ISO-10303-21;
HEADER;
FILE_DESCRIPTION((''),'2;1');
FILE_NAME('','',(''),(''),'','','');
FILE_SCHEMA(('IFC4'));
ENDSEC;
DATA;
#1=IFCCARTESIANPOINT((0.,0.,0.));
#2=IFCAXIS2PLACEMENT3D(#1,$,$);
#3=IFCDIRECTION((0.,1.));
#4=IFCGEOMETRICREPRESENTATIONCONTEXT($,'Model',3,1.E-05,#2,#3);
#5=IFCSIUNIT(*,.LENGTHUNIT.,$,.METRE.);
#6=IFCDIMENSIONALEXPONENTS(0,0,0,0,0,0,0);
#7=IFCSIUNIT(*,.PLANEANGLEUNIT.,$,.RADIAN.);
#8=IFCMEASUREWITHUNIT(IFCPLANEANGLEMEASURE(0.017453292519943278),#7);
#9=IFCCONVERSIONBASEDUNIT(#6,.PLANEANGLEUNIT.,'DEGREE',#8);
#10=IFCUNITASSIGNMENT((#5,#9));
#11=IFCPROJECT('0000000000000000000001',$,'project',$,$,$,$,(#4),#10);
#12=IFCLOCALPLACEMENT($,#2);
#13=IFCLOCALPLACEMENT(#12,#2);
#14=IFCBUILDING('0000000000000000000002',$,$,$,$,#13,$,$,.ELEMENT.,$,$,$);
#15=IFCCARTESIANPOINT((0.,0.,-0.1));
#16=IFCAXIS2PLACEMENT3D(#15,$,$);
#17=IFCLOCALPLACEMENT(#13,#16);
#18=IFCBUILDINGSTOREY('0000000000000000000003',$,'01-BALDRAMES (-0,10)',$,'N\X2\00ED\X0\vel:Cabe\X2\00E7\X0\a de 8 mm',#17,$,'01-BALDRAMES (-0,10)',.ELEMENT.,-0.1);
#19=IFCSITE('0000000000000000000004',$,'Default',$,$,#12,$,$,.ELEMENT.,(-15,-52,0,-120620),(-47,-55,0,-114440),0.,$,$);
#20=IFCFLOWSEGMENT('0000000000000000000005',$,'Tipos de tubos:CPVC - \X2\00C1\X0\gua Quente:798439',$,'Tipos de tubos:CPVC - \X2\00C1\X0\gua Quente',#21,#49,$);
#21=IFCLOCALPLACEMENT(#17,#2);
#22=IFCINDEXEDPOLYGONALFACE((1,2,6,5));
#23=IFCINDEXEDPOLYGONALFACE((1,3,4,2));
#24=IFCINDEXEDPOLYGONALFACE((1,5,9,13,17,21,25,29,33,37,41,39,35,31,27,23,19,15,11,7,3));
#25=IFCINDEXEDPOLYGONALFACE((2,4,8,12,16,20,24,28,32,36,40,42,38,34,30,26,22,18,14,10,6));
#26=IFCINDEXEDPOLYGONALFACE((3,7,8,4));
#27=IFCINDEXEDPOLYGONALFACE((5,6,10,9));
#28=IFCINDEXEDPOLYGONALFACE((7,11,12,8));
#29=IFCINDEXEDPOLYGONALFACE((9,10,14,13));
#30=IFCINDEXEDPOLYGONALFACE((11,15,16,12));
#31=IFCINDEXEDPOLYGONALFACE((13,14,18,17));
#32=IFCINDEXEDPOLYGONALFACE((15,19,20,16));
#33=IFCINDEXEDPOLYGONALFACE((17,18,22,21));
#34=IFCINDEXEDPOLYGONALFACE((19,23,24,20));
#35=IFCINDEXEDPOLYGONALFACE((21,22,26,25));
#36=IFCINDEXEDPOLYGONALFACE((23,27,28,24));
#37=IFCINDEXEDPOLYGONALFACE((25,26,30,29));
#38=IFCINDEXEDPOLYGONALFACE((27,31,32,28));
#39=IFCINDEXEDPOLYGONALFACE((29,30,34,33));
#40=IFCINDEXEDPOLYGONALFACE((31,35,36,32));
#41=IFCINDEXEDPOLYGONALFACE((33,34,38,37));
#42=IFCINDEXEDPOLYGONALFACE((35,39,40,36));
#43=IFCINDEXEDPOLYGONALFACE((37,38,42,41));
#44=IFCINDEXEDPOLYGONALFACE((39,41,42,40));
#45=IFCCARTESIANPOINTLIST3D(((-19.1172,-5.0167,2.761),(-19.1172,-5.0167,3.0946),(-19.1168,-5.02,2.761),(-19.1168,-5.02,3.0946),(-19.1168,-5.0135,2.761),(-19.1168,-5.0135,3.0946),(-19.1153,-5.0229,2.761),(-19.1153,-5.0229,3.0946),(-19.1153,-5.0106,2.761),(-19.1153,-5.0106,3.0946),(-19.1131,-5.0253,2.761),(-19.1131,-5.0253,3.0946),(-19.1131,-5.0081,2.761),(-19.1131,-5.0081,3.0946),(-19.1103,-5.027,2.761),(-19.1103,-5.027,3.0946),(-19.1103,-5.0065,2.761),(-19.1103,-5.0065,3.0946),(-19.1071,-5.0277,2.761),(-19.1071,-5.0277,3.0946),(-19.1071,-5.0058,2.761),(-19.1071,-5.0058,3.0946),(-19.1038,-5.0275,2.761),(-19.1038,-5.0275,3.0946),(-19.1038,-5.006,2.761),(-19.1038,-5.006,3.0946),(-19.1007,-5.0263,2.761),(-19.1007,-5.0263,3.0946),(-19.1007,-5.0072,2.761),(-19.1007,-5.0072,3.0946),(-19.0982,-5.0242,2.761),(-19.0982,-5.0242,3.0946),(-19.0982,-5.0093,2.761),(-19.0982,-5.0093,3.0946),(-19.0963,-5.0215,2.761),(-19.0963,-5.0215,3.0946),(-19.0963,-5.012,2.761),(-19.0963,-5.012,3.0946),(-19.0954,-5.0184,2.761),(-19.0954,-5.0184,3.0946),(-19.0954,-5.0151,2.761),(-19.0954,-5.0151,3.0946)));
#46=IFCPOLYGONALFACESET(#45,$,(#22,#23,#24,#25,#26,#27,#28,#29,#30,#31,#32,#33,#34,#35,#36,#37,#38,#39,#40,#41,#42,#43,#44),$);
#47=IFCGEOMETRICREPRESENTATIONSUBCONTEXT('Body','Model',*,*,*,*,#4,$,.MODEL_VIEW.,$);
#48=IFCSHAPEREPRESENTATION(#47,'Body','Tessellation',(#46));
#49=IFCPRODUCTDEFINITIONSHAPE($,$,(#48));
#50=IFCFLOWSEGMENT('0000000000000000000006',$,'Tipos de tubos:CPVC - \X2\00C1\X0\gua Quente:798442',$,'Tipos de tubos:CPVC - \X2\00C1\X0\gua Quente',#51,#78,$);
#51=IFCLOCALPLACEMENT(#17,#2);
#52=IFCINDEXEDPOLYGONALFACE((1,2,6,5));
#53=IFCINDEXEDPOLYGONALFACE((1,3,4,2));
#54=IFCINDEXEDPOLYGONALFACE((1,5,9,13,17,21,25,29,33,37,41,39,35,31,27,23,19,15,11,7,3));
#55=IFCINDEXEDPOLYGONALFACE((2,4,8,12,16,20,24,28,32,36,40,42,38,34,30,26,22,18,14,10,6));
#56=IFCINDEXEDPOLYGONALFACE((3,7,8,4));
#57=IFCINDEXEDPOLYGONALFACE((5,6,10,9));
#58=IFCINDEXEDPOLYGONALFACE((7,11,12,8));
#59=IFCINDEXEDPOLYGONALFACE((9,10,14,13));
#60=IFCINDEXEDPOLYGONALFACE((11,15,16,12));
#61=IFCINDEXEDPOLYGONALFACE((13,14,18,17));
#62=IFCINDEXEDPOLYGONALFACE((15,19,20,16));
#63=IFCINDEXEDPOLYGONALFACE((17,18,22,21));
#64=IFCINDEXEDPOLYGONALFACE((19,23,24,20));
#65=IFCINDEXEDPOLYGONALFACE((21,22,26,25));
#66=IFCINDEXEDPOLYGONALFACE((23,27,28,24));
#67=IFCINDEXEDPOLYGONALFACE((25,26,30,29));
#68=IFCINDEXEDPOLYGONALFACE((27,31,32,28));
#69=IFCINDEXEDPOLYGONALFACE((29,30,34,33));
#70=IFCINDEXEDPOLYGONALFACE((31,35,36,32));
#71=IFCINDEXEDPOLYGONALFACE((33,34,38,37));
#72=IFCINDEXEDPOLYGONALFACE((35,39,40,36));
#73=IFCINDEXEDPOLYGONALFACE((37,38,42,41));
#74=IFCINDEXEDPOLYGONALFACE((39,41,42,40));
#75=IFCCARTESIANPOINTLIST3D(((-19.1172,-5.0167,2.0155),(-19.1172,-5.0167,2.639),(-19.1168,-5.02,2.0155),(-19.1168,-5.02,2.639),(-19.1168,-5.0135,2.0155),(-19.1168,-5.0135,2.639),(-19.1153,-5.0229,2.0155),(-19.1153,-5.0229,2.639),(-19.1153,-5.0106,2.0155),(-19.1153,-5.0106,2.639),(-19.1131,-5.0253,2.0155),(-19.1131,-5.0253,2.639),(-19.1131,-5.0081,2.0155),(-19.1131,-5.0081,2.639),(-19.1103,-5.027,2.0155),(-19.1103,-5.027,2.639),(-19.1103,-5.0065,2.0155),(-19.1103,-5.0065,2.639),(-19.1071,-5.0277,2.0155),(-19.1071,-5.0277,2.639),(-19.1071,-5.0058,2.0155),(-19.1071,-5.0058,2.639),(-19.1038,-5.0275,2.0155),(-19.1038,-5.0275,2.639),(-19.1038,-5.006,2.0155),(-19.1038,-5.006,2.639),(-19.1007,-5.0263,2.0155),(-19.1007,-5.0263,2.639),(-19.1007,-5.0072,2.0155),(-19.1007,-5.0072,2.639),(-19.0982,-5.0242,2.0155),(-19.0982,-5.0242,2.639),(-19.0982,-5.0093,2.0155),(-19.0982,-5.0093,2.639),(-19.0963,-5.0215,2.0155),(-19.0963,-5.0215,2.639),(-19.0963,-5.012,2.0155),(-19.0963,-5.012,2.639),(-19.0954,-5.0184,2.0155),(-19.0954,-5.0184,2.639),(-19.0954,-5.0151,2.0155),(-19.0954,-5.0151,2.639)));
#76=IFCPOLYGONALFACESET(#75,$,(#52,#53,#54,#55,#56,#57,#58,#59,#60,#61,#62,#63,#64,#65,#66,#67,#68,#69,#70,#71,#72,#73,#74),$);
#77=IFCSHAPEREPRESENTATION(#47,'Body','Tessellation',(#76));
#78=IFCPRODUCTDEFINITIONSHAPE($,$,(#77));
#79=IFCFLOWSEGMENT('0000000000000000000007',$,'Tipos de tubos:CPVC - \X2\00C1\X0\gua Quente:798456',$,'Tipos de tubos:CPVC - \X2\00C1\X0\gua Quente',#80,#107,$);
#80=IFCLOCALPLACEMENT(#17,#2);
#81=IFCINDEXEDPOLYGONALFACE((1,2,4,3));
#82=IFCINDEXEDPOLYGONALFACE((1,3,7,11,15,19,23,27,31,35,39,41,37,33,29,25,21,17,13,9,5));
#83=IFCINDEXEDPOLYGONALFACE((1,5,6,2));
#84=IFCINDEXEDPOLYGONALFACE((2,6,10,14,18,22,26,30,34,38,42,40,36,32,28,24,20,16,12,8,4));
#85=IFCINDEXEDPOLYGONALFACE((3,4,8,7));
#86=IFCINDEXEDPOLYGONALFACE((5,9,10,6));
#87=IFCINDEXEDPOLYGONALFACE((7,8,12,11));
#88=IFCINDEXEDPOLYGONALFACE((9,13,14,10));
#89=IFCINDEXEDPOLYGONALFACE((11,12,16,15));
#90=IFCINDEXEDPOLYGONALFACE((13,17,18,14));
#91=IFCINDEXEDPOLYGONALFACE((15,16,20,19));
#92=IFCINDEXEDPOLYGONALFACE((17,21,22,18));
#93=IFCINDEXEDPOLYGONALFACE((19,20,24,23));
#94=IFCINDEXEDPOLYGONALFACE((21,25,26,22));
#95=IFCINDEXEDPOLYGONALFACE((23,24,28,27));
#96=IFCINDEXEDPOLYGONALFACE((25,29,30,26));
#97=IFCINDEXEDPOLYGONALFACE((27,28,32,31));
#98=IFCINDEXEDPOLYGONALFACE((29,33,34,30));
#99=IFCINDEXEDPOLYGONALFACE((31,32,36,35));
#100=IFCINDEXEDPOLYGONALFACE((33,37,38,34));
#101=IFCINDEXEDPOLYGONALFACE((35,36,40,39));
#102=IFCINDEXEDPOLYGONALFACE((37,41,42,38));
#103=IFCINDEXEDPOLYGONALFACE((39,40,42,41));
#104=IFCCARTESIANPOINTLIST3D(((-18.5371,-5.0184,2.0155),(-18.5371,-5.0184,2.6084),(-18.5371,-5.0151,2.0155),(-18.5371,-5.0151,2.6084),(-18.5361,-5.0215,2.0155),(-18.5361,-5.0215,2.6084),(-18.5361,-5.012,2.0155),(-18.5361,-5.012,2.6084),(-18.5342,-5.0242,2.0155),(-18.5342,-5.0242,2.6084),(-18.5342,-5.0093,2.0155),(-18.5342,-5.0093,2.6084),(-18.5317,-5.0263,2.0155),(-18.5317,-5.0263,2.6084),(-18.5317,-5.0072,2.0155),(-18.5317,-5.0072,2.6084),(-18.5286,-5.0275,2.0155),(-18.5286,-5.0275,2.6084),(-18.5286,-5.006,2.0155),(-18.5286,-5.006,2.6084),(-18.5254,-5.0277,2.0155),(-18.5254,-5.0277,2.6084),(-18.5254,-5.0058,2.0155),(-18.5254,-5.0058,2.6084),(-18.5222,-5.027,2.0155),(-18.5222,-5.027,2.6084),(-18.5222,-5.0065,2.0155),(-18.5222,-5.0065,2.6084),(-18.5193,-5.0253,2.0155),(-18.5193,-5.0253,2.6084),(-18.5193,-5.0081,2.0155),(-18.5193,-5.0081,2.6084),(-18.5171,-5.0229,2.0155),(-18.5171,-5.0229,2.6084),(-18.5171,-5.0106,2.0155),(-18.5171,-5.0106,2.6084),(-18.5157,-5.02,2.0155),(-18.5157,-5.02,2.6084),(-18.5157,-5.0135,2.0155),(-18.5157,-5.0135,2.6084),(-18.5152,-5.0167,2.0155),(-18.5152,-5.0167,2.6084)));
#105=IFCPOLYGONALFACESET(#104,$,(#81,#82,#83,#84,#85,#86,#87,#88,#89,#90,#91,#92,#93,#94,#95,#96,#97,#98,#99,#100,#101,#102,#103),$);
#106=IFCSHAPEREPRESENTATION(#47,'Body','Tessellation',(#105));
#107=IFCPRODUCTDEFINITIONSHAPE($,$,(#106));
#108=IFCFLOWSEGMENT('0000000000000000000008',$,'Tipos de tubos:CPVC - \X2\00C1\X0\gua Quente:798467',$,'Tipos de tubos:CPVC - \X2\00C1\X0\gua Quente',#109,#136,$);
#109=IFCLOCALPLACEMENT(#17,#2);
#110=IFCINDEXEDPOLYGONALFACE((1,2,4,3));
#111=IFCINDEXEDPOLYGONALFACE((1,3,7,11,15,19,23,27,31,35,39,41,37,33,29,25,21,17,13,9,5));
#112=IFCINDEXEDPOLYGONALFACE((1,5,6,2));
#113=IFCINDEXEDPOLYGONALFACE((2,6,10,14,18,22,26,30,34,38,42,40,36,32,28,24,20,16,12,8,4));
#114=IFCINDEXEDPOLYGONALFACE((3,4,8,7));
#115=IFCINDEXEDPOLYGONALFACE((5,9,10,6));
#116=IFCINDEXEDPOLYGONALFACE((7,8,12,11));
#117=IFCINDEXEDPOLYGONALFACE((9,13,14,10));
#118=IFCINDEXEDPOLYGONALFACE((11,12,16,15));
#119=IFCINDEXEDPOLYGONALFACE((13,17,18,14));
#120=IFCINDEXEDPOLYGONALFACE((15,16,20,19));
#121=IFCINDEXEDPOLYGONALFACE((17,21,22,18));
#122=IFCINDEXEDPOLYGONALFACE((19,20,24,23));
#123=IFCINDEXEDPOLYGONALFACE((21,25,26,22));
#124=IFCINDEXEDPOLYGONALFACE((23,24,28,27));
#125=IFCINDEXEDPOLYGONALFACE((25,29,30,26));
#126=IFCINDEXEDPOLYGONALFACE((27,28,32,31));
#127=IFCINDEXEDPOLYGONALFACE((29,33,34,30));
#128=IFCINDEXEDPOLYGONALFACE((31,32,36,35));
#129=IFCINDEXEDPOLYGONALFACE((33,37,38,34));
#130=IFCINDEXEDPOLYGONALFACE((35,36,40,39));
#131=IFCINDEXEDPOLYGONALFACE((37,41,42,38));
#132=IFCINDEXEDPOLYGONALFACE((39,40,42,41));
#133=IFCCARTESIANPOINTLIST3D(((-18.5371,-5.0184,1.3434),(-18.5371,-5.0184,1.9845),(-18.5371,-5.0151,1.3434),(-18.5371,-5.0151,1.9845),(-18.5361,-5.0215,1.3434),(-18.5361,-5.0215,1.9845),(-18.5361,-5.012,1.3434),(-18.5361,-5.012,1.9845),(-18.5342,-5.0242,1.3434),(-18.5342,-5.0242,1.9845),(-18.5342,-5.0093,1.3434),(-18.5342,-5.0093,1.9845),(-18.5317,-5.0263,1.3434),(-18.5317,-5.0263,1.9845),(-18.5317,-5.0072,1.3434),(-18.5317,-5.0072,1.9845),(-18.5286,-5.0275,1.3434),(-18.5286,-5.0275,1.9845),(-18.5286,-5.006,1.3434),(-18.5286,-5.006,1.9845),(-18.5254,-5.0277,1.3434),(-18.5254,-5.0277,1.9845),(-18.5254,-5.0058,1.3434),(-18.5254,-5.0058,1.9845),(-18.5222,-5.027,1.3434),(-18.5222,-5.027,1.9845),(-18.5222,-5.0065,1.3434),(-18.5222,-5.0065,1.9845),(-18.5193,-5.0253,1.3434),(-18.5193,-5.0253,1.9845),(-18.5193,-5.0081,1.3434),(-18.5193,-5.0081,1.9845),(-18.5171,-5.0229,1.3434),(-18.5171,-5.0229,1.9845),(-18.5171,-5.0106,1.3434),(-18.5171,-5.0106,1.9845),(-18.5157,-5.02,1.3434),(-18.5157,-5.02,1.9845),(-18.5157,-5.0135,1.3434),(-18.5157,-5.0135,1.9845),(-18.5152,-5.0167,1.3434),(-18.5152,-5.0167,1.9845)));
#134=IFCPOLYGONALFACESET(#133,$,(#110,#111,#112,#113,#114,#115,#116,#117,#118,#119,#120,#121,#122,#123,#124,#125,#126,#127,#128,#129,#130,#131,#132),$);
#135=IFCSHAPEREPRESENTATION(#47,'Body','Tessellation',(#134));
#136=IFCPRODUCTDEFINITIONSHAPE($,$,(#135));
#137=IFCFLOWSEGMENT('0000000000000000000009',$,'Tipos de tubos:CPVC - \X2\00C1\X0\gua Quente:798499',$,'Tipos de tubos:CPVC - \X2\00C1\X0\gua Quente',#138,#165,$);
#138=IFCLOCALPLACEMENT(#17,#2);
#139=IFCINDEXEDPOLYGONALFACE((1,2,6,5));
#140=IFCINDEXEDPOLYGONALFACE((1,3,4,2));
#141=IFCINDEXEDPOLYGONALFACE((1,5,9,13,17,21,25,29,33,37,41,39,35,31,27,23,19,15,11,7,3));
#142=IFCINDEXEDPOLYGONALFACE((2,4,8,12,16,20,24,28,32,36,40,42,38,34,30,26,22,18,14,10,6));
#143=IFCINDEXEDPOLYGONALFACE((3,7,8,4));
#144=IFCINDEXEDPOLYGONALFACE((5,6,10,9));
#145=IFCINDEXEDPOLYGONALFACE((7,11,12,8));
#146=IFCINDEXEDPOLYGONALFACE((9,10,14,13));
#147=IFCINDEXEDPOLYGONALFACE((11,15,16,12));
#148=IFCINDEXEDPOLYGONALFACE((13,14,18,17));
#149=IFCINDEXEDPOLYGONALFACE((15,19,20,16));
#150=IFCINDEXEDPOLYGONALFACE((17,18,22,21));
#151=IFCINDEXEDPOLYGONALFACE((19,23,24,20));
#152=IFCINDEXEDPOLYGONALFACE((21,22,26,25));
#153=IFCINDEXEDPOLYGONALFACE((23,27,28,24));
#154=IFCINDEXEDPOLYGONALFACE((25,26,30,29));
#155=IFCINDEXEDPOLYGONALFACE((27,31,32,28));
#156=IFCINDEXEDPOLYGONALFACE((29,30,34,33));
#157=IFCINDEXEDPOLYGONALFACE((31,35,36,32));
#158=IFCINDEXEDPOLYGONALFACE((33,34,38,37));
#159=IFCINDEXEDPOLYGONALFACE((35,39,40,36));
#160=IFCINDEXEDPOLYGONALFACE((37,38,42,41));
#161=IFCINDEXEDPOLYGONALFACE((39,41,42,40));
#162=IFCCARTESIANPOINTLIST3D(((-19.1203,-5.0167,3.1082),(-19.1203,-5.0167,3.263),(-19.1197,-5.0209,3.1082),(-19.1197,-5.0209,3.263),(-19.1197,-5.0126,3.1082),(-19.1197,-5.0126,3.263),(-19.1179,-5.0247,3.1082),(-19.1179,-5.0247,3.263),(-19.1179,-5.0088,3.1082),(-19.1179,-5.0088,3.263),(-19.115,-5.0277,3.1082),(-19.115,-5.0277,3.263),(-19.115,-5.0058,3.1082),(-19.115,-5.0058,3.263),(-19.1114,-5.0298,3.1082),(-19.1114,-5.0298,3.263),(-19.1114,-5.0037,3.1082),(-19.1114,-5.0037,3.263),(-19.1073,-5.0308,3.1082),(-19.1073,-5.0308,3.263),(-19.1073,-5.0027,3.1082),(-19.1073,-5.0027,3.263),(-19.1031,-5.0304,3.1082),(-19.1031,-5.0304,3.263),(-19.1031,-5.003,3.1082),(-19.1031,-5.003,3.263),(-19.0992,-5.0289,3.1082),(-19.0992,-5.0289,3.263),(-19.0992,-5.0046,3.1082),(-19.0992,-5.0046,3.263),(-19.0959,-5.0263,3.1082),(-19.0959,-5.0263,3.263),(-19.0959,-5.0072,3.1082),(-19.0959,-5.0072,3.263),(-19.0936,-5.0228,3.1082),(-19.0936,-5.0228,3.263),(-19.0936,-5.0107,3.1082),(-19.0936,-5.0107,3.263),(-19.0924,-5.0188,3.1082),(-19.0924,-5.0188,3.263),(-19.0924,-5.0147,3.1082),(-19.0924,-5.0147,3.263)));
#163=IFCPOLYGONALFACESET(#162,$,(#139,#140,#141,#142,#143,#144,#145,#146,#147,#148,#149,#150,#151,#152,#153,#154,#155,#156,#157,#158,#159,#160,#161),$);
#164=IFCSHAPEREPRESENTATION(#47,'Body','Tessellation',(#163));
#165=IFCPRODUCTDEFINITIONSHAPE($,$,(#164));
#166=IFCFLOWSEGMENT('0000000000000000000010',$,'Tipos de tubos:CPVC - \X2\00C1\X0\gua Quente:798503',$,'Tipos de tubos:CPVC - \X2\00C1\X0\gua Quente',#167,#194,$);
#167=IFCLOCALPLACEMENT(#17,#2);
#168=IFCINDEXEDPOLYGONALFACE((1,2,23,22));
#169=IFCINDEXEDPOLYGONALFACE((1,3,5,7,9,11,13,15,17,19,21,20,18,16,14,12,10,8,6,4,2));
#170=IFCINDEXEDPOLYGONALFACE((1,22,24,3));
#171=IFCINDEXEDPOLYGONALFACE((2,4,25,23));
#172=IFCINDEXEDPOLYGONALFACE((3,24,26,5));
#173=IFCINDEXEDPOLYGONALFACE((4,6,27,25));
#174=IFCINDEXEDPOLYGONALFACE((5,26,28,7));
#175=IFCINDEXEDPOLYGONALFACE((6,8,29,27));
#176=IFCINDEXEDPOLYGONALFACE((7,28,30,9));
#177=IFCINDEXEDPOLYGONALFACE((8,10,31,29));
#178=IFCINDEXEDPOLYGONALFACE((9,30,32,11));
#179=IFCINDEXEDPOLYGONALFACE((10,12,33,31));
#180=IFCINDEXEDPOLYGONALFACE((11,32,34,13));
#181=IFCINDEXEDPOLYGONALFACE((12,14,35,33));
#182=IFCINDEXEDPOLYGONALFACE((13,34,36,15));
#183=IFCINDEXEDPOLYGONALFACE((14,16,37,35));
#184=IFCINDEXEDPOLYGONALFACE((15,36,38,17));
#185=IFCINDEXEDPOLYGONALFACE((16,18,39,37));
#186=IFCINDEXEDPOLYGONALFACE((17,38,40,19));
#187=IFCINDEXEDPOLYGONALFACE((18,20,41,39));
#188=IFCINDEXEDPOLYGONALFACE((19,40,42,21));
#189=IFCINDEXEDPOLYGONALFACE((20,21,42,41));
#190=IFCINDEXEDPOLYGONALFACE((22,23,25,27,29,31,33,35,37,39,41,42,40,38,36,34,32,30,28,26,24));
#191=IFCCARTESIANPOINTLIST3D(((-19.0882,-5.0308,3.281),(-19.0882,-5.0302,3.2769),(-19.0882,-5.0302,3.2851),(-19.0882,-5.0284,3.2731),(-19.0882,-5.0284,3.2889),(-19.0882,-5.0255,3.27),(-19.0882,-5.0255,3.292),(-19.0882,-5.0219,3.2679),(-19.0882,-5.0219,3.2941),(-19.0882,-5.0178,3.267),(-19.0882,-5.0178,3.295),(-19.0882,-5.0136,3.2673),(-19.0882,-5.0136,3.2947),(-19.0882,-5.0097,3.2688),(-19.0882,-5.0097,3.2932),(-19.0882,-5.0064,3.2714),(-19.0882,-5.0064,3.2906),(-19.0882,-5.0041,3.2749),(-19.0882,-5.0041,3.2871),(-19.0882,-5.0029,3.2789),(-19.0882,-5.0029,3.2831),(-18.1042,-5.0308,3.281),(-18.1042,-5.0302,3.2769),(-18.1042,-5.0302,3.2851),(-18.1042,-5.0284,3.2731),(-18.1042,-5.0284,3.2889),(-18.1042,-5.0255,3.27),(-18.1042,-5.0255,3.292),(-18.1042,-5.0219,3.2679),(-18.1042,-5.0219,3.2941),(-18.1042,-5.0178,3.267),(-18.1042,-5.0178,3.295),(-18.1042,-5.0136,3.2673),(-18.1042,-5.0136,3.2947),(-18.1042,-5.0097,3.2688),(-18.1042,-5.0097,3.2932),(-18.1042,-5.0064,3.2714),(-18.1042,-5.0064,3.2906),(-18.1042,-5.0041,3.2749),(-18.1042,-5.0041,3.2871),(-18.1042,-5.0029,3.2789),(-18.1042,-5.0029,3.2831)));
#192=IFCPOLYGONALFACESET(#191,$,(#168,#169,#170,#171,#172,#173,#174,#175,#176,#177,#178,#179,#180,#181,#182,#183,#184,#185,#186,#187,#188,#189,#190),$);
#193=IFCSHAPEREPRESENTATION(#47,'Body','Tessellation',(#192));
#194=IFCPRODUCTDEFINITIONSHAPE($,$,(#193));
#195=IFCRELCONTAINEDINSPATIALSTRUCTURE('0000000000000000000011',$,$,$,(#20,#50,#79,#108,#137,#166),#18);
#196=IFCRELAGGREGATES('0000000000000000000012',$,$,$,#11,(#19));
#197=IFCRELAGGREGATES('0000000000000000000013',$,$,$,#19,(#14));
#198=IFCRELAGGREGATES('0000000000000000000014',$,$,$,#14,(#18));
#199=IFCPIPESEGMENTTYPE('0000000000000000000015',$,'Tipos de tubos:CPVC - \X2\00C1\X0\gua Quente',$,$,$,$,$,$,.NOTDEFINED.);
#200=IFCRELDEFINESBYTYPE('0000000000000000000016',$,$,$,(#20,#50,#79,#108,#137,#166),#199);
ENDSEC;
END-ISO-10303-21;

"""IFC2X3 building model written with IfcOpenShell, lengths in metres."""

from ifc_helpers import new_model, entity, si_unit, converted_unit, direction, frame, frame_2d, origin, origin_2d_with_axis, place, context, subcontext, project, spatial, circle, extrude, type_object, element, save


model = new_model("IFC2X3")

# Units and contexts
model_context = context("Model", 3, precision=1e-05, world=origin(), true_north=direction((0.0, 1.0)))
body_context = subcontext(model_context, "Body", "Model", "MODEL_VIEW")
ifc_project = project(units=[si_unit("LENGTHUNIT", "METRE"), converted_unit("PLANEANGLEUNIT", "DEGREE", entity("IfcPlaneAngleMeasure", 0.017453292519943278), si_unit("PLANEANGLEUNIT", "RADIAN"), dimensions=[0, 0, 0, 0, 0, 0, 0])], contexts=[model_context])

# Site, building, storey
site_placement = place(None, origin())
site = spatial("IfcSite", under=ifc_project, at=site_placement, Name="Default", CompositionType="ELEMENT", RefLatitude=(-15, -52, 0, -120620), RefLongitude=(-47, -55, 0, -114440), RefElevation=0.0)
building_placement = place(site_placement, origin())
building = spatial("IfcBuilding", under=site, at=building_placement, CompositionType="ELEMENT")
storey_placement = place(building_placement, frame((0.0, 0.0, -0.1)))
storey = spatial("IfcBuildingStorey", under=building, at=storey_placement, Name="01-BALDRAMES (-0,10)", ObjectType="Nível:Cabeça de 8 mm", LongName="01-BALDRAMES (-0,10)", CompositionType="ELEMENT", Elevation=-0.1)

# Flow segments
pipe_segment_type_1 = type_object("IfcPipeSegmentType", Name="Tipos de tubos:CPVC - Água Quente", PredefinedType="NOTDEFINED")
flow_segment_1_placement = place(storey_placement, origin())
element("IfcFlowSegment", 1, at=flow_segment_1_placement, inside=storey, type_object=pipe_segment_type_1, Name="Tipos de tubos:CPVC - Água Quente:798439", ObjectType="Tipos de tubos:CPVC - Água Quente", context=body_context, shape_type="SweptSolid", body=[
    extrude(circle(Radius=0.011, at=origin_2d_with_axis()), frame((-19.1062, -5.0167, 2.761), z_axis=(0.0, 0.0, 1.0), x_axis=(-1.0, 0.0, 0.0)), (0.0, 0.0, 1.0), 0.3336),
])
flow_segment_2_placement = place(storey_placement, origin())
element("IfcFlowSegment", 2, at=flow_segment_2_placement, inside=storey, type_object=pipe_segment_type_1, Name="Tipos de tubos:CPVC - Água Quente:798442", ObjectType="Tipos de tubos:CPVC - Água Quente", context=body_context, shape_type="SweptSolid", body=[
    extrude(circle(Radius=0.011, at=origin_2d_with_axis()), frame((-19.1062, -5.0167, 2.0155), z_axis=(0.0, 0.0, 1.0), x_axis=(-1.0, 0.0, 0.0)), (0.0, 0.0, 1.0), 0.6235),
])
flow_segment_3_placement = place(storey_placement, origin())
element("IfcFlowSegment", 3, at=flow_segment_3_placement, inside=storey, type_object=pipe_segment_type_1, Name="Tipos de tubos:CPVC - Água Quente:798456", ObjectType="Tipos de tubos:CPVC - Água Quente", context=body_context, shape_type="SweptSolid", body=[
    extrude(circle(Radius=0.011, at=origin_2d_with_axis()), frame((-18.5262, -5.0167, 2.0155)), (0.0, 0.0, 1.0), 0.5929),
])
flow_segment_4_placement = place(storey_placement, origin())
element("IfcFlowSegment", 4, at=flow_segment_4_placement, inside=storey, type_object=pipe_segment_type_1, Name="Tipos de tubos:CPVC - Água Quente:798467", ObjectType="Tipos de tubos:CPVC - Água Quente", context=body_context, shape_type="SweptSolid", body=[
    extrude(circle(Radius=0.011, at=origin_2d_with_axis()), frame((-18.5262, -5.0167, 1.3434)), (0.0, 0.0, 1.0), 0.6411),
])
flow_segment_5_placement = place(storey_placement, origin())
element("IfcFlowSegment", 5, at=flow_segment_5_placement, inside=storey, type_object=pipe_segment_type_1, Name="Tipos de tubos:CPVC - Água Quente:798499", ObjectType="Tipos de tubos:CPVC - Água Quente", context=body_context, shape_type="SweptSolid", body=[
    extrude(circle(Radius=0.0141, at=frame_2d((0.0, 0.0), x_axis=(1.0, 0.0))), frame((-19.1062, -5.0167, 3.1082), z_axis=(0.0, 0.0, 1.0), x_axis=(-1.0, 0.0, 0.0)), (0.0, 0.0, 1.0), 0.1548),
])
flow_segment_6_placement = place(storey_placement, origin())
element("IfcFlowSegment", 6, at=flow_segment_6_placement, inside=storey, type_object=pipe_segment_type_1, Name="Tipos de tubos:CPVC - Água Quente:798503", ObjectType="Tipos de tubos:CPVC - Água Quente", context=body_context, shape_type="SweptSolid", body=[
    extrude(circle(Radius=0.0141, at=origin_2d_with_axis()), frame((-19.0882, -5.0167, 3.281), z_axis=(1.0, 0.0, 0.0), x_axis=(0.0, -1.0, 0.0)), (0.0, 0.0, 1.0), 0.984),
])

save(model, "model.ifc")
